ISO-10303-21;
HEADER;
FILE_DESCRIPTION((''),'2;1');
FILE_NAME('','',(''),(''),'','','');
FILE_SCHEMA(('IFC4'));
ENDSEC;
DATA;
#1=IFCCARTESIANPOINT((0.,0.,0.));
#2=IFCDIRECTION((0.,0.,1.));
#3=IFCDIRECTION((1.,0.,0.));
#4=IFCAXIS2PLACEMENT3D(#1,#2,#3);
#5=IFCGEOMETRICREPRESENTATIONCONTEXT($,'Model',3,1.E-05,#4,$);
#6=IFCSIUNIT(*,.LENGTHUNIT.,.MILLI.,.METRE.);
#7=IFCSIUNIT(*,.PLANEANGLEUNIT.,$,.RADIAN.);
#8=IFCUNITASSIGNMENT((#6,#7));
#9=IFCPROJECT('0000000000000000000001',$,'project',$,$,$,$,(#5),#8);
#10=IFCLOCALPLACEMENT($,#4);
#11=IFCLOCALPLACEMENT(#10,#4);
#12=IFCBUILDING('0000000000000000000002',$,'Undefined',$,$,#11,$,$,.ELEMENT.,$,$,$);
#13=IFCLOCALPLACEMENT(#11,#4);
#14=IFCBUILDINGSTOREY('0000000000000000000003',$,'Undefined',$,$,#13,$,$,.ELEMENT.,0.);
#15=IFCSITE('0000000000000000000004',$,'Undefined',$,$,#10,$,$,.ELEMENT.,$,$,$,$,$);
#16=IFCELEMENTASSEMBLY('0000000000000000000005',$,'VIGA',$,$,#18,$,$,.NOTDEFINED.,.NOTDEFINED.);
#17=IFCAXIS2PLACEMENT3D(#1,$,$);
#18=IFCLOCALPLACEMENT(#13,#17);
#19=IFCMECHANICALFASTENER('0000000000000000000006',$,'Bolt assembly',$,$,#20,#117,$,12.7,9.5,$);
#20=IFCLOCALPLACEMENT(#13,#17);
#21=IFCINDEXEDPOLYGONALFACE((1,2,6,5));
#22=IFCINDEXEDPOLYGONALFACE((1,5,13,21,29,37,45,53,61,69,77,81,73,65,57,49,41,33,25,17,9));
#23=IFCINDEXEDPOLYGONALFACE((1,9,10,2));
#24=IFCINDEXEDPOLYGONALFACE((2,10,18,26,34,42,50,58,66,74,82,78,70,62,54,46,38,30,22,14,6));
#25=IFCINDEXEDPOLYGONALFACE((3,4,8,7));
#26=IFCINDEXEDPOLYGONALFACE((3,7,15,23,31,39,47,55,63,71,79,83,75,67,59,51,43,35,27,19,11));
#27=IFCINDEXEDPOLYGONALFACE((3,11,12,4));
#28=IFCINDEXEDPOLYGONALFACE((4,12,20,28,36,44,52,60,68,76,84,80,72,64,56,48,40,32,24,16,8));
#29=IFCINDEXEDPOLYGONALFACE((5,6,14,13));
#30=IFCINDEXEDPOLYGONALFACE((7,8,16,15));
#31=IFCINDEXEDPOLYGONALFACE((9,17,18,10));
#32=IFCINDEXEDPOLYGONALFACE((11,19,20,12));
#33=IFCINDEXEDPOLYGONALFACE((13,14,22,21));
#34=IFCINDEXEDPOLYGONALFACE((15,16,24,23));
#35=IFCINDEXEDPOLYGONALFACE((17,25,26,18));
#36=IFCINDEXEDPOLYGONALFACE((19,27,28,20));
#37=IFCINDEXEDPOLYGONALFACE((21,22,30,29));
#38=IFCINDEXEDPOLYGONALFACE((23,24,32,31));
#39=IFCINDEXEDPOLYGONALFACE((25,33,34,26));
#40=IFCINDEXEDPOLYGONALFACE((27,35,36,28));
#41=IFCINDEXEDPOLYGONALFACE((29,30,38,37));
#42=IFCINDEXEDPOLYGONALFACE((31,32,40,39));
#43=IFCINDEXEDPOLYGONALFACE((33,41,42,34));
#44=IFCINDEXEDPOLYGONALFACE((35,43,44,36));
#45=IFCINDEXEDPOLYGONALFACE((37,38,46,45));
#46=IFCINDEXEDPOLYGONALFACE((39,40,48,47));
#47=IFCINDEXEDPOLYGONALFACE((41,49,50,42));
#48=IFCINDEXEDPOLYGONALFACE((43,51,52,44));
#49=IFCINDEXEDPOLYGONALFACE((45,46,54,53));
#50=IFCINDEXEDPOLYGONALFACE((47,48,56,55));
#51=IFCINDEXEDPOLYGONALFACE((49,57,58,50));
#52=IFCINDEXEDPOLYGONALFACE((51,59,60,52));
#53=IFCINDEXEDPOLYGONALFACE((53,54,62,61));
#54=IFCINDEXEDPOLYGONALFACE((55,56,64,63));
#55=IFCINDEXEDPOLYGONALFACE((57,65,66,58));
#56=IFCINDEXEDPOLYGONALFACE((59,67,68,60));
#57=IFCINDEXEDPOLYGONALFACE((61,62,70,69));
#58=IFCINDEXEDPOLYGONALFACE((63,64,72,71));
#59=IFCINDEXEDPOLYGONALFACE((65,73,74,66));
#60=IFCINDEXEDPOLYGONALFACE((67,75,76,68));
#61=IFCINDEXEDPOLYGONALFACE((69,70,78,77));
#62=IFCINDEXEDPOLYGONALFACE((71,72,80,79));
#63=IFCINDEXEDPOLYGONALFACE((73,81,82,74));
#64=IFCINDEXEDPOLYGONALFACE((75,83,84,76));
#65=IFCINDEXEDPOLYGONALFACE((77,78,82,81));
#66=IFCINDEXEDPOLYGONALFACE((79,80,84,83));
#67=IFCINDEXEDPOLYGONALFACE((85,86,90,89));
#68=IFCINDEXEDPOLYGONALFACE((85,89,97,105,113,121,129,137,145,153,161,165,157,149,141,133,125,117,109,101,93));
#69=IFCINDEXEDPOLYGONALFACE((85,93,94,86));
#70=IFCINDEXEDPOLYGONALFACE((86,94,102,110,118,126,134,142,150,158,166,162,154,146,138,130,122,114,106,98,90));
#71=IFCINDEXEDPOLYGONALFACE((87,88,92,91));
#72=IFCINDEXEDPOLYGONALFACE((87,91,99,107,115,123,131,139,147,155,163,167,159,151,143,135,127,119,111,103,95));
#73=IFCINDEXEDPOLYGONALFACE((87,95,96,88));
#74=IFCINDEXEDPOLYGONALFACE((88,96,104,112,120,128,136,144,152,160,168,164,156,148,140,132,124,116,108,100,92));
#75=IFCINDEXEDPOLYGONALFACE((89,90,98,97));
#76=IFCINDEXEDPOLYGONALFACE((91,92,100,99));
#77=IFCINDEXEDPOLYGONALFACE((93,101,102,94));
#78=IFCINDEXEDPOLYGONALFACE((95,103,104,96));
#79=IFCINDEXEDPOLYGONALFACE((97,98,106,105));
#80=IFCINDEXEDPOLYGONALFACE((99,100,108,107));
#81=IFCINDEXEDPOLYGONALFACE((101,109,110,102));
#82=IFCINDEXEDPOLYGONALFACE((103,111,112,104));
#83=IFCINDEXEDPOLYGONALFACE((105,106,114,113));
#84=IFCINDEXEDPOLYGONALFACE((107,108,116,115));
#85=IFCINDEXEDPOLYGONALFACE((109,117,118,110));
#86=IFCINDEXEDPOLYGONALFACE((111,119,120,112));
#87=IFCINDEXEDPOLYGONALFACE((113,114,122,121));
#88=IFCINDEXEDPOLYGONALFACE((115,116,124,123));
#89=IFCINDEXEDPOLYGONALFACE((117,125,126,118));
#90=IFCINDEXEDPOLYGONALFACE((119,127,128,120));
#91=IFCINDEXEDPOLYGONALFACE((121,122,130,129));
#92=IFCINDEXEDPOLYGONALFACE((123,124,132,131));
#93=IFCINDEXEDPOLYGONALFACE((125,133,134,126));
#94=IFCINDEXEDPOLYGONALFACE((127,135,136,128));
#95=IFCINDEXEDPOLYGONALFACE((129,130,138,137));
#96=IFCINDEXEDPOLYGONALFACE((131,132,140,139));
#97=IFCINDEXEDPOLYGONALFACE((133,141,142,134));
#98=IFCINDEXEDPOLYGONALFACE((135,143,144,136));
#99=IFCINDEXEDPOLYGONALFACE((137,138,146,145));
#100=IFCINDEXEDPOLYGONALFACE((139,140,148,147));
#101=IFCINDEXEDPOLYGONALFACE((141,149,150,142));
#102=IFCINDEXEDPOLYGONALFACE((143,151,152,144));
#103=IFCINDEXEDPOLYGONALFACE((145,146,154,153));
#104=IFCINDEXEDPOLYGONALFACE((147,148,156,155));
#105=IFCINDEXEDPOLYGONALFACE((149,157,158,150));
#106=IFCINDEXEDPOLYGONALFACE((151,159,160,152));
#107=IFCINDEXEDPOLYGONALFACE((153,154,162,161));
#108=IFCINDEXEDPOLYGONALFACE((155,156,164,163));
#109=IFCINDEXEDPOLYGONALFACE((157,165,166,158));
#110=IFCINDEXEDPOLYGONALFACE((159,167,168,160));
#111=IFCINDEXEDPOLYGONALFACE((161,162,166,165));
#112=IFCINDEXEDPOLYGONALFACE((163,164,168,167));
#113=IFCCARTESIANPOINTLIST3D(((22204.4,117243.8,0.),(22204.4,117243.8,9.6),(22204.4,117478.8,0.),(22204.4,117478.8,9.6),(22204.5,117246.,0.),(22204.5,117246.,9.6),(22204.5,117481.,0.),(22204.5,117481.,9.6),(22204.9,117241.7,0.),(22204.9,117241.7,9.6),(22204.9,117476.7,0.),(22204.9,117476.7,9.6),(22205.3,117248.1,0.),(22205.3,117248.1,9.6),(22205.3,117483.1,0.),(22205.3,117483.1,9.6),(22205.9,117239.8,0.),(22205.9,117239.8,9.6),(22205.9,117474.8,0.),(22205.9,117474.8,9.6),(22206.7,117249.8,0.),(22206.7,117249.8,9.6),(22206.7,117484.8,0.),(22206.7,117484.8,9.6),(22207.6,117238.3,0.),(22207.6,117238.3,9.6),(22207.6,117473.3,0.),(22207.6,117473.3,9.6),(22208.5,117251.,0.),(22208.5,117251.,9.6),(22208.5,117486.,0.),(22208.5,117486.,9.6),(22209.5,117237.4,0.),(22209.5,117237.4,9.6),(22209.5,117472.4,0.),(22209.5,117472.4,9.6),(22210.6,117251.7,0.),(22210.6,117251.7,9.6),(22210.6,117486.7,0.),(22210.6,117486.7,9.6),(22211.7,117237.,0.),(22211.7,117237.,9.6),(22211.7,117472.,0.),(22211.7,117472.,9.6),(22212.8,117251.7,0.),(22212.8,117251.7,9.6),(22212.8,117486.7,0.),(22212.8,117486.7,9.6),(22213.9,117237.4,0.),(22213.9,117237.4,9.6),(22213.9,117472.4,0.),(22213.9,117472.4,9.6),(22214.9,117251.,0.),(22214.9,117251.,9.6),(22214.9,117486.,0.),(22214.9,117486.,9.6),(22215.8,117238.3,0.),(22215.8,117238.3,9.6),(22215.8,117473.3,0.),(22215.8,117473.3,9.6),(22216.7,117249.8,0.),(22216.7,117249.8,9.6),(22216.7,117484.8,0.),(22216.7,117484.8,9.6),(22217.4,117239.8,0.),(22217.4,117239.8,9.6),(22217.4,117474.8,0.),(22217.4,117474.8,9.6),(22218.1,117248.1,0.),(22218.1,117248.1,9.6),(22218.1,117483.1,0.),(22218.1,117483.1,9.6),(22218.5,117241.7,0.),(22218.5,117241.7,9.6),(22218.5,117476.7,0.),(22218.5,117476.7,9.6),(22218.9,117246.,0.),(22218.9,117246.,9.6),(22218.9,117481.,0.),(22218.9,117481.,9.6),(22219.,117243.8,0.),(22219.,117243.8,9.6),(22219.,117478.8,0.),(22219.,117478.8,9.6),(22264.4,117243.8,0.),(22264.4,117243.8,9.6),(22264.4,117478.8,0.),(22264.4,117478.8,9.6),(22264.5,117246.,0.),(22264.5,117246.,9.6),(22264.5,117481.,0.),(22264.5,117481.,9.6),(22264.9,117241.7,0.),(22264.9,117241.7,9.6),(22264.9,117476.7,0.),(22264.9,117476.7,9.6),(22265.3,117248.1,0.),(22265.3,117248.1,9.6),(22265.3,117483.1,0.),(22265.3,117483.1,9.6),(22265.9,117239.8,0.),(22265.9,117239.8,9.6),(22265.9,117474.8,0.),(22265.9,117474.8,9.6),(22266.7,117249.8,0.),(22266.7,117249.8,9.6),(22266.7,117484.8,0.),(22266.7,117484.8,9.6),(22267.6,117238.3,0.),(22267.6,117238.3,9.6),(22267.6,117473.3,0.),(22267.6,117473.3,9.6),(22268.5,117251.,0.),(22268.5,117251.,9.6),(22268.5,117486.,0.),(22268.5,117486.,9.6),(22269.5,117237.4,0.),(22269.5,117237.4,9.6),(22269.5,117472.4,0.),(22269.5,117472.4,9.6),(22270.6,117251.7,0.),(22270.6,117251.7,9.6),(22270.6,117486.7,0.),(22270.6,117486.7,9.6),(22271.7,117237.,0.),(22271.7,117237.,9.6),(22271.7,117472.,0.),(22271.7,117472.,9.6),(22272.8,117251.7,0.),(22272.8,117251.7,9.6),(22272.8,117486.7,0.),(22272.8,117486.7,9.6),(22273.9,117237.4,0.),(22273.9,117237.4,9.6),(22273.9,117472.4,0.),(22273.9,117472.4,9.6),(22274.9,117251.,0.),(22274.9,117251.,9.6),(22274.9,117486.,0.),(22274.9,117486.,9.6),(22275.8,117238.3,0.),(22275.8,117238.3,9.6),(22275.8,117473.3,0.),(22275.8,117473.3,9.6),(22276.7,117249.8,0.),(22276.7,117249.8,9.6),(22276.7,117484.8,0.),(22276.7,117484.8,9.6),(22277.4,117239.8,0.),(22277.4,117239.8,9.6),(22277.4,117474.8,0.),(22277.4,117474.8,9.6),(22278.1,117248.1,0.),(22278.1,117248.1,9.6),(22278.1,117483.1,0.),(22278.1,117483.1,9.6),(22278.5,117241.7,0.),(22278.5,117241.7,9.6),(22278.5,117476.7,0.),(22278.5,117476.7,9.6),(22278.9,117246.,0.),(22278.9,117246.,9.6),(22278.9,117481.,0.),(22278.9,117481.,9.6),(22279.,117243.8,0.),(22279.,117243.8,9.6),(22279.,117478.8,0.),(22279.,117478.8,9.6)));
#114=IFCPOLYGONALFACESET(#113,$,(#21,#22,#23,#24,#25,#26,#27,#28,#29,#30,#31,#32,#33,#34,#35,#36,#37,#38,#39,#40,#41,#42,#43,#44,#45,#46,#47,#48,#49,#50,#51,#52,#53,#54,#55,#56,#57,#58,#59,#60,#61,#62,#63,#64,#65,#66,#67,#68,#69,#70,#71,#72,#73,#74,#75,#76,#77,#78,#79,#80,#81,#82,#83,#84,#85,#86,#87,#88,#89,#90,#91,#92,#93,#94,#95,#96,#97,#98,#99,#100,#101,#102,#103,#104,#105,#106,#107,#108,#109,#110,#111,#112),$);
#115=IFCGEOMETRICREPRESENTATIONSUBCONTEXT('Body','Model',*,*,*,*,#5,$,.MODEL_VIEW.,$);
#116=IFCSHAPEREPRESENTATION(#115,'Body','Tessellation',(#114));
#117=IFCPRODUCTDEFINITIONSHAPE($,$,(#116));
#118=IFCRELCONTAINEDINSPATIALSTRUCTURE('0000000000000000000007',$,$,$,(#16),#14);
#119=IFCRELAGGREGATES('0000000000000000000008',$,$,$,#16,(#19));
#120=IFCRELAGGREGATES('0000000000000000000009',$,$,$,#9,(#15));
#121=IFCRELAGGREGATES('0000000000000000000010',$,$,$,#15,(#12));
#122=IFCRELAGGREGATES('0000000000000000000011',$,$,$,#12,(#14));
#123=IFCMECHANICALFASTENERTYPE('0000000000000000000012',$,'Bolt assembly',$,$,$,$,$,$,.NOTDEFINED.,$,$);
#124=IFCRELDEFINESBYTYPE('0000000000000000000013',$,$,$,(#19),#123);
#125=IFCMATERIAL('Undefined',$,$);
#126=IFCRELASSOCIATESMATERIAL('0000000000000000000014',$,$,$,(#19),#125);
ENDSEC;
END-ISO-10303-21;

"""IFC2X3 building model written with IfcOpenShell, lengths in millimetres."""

from ifc_helpers import new_model, si_unit, frame, origin_with_axes, origin_2d_with_axis, place, context, subcontext, project, spatial, circle, extrude, source, transform, mapped, material, type_object, element, aggregate, save


model = new_model("IFC2X3")

# Units and contexts
model_context = context("Model", 3, precision=1e-05, world=origin_with_axes())
body_context = subcontext(model_context, "Body", "Model", "MODEL_VIEW")
ifc_project = project(units=[si_unit("LENGTHUNIT", "METRE", prefix="MILLI"), si_unit("PLANEANGLEUNIT", "RADIAN")], contexts=[model_context])

# Site, building, storey
site_placement = place(None, origin_with_axes())
site = spatial("IfcSite", under=ifc_project, at=site_placement, Name="Undefined", CompositionType="ELEMENT")
building_placement = place(site_placement, origin_with_axes())
building = spatial("IfcBuilding", under=site, at=building_placement, Name="Undefined", CompositionType="ELEMENT")
storey_placement = place(building_placement, origin_with_axes())
storey = spatial("IfcBuildingStorey", under=building, at=storey_placement, Name="Undefined", CompositionType="ELEMENT", Elevation=0.0)

# Element assembly
assembly_1_placement = place(storey_placement, origin_with_axes())
assembly_1 = element("IfcElementAssembly", 1, at=assembly_1_placement, inside=storey, Name="VIGA", AssemblyPlace="NOTDEFINED", PredefinedType="NOTDEFINED")

# Shared definitions
ifc_material_1 = material(Name="Undefined")
mechanical_fastener_type = type_object("IfcMechanicalFastenerType", Name="Bolt assembly")

# Mechanical fastener
shared_shape_1 = source(origin_with_axes(), body_context, "Body", "SweptSolid", [
    extrude(circle(Radius=7.3, at=origin_2d_with_axis()), frame((0.0, -9.5, 0.0), z_axis=(0.0, 1.0, 0.0), x_axis=(1.0, 0.0, 0.0)), (0.0, 0.0, 1.0), 9.6),
])
mechanical_fastener_1_placement = place(assembly_1_placement, frame((22241.7, 117479.4, 9.5), z_axis=(-1.0, 0.0, 0.0), x_axis=(0.0, -1.0, 0.0)))
mechanical_fastener_1 = element("IfcMechanicalFastener", 2, at=mechanical_fastener_1_placement, type_object=mechanical_fastener_type, material=ifc_material_1, Name="Bolt assembly", NominalDiameter=12.7, NominalLength=9.5, context=body_context, shape_type="MappedRepresentation", body=[
    mapped(shared_shape_1, transform((0.0, 0.0, 30.0))),
    mapped(shared_shape_1, transform((235.0, 0.0, 30.0))),
    mapped(shared_shape_1, transform((0.0, 0.0, -30.0))),
    mapped(shared_shape_1, transform((235.0, 0.0, -30.0))),
])
aggregate(assembly_1, [mechanical_fastener_1])

save(model, "model.ifc")
